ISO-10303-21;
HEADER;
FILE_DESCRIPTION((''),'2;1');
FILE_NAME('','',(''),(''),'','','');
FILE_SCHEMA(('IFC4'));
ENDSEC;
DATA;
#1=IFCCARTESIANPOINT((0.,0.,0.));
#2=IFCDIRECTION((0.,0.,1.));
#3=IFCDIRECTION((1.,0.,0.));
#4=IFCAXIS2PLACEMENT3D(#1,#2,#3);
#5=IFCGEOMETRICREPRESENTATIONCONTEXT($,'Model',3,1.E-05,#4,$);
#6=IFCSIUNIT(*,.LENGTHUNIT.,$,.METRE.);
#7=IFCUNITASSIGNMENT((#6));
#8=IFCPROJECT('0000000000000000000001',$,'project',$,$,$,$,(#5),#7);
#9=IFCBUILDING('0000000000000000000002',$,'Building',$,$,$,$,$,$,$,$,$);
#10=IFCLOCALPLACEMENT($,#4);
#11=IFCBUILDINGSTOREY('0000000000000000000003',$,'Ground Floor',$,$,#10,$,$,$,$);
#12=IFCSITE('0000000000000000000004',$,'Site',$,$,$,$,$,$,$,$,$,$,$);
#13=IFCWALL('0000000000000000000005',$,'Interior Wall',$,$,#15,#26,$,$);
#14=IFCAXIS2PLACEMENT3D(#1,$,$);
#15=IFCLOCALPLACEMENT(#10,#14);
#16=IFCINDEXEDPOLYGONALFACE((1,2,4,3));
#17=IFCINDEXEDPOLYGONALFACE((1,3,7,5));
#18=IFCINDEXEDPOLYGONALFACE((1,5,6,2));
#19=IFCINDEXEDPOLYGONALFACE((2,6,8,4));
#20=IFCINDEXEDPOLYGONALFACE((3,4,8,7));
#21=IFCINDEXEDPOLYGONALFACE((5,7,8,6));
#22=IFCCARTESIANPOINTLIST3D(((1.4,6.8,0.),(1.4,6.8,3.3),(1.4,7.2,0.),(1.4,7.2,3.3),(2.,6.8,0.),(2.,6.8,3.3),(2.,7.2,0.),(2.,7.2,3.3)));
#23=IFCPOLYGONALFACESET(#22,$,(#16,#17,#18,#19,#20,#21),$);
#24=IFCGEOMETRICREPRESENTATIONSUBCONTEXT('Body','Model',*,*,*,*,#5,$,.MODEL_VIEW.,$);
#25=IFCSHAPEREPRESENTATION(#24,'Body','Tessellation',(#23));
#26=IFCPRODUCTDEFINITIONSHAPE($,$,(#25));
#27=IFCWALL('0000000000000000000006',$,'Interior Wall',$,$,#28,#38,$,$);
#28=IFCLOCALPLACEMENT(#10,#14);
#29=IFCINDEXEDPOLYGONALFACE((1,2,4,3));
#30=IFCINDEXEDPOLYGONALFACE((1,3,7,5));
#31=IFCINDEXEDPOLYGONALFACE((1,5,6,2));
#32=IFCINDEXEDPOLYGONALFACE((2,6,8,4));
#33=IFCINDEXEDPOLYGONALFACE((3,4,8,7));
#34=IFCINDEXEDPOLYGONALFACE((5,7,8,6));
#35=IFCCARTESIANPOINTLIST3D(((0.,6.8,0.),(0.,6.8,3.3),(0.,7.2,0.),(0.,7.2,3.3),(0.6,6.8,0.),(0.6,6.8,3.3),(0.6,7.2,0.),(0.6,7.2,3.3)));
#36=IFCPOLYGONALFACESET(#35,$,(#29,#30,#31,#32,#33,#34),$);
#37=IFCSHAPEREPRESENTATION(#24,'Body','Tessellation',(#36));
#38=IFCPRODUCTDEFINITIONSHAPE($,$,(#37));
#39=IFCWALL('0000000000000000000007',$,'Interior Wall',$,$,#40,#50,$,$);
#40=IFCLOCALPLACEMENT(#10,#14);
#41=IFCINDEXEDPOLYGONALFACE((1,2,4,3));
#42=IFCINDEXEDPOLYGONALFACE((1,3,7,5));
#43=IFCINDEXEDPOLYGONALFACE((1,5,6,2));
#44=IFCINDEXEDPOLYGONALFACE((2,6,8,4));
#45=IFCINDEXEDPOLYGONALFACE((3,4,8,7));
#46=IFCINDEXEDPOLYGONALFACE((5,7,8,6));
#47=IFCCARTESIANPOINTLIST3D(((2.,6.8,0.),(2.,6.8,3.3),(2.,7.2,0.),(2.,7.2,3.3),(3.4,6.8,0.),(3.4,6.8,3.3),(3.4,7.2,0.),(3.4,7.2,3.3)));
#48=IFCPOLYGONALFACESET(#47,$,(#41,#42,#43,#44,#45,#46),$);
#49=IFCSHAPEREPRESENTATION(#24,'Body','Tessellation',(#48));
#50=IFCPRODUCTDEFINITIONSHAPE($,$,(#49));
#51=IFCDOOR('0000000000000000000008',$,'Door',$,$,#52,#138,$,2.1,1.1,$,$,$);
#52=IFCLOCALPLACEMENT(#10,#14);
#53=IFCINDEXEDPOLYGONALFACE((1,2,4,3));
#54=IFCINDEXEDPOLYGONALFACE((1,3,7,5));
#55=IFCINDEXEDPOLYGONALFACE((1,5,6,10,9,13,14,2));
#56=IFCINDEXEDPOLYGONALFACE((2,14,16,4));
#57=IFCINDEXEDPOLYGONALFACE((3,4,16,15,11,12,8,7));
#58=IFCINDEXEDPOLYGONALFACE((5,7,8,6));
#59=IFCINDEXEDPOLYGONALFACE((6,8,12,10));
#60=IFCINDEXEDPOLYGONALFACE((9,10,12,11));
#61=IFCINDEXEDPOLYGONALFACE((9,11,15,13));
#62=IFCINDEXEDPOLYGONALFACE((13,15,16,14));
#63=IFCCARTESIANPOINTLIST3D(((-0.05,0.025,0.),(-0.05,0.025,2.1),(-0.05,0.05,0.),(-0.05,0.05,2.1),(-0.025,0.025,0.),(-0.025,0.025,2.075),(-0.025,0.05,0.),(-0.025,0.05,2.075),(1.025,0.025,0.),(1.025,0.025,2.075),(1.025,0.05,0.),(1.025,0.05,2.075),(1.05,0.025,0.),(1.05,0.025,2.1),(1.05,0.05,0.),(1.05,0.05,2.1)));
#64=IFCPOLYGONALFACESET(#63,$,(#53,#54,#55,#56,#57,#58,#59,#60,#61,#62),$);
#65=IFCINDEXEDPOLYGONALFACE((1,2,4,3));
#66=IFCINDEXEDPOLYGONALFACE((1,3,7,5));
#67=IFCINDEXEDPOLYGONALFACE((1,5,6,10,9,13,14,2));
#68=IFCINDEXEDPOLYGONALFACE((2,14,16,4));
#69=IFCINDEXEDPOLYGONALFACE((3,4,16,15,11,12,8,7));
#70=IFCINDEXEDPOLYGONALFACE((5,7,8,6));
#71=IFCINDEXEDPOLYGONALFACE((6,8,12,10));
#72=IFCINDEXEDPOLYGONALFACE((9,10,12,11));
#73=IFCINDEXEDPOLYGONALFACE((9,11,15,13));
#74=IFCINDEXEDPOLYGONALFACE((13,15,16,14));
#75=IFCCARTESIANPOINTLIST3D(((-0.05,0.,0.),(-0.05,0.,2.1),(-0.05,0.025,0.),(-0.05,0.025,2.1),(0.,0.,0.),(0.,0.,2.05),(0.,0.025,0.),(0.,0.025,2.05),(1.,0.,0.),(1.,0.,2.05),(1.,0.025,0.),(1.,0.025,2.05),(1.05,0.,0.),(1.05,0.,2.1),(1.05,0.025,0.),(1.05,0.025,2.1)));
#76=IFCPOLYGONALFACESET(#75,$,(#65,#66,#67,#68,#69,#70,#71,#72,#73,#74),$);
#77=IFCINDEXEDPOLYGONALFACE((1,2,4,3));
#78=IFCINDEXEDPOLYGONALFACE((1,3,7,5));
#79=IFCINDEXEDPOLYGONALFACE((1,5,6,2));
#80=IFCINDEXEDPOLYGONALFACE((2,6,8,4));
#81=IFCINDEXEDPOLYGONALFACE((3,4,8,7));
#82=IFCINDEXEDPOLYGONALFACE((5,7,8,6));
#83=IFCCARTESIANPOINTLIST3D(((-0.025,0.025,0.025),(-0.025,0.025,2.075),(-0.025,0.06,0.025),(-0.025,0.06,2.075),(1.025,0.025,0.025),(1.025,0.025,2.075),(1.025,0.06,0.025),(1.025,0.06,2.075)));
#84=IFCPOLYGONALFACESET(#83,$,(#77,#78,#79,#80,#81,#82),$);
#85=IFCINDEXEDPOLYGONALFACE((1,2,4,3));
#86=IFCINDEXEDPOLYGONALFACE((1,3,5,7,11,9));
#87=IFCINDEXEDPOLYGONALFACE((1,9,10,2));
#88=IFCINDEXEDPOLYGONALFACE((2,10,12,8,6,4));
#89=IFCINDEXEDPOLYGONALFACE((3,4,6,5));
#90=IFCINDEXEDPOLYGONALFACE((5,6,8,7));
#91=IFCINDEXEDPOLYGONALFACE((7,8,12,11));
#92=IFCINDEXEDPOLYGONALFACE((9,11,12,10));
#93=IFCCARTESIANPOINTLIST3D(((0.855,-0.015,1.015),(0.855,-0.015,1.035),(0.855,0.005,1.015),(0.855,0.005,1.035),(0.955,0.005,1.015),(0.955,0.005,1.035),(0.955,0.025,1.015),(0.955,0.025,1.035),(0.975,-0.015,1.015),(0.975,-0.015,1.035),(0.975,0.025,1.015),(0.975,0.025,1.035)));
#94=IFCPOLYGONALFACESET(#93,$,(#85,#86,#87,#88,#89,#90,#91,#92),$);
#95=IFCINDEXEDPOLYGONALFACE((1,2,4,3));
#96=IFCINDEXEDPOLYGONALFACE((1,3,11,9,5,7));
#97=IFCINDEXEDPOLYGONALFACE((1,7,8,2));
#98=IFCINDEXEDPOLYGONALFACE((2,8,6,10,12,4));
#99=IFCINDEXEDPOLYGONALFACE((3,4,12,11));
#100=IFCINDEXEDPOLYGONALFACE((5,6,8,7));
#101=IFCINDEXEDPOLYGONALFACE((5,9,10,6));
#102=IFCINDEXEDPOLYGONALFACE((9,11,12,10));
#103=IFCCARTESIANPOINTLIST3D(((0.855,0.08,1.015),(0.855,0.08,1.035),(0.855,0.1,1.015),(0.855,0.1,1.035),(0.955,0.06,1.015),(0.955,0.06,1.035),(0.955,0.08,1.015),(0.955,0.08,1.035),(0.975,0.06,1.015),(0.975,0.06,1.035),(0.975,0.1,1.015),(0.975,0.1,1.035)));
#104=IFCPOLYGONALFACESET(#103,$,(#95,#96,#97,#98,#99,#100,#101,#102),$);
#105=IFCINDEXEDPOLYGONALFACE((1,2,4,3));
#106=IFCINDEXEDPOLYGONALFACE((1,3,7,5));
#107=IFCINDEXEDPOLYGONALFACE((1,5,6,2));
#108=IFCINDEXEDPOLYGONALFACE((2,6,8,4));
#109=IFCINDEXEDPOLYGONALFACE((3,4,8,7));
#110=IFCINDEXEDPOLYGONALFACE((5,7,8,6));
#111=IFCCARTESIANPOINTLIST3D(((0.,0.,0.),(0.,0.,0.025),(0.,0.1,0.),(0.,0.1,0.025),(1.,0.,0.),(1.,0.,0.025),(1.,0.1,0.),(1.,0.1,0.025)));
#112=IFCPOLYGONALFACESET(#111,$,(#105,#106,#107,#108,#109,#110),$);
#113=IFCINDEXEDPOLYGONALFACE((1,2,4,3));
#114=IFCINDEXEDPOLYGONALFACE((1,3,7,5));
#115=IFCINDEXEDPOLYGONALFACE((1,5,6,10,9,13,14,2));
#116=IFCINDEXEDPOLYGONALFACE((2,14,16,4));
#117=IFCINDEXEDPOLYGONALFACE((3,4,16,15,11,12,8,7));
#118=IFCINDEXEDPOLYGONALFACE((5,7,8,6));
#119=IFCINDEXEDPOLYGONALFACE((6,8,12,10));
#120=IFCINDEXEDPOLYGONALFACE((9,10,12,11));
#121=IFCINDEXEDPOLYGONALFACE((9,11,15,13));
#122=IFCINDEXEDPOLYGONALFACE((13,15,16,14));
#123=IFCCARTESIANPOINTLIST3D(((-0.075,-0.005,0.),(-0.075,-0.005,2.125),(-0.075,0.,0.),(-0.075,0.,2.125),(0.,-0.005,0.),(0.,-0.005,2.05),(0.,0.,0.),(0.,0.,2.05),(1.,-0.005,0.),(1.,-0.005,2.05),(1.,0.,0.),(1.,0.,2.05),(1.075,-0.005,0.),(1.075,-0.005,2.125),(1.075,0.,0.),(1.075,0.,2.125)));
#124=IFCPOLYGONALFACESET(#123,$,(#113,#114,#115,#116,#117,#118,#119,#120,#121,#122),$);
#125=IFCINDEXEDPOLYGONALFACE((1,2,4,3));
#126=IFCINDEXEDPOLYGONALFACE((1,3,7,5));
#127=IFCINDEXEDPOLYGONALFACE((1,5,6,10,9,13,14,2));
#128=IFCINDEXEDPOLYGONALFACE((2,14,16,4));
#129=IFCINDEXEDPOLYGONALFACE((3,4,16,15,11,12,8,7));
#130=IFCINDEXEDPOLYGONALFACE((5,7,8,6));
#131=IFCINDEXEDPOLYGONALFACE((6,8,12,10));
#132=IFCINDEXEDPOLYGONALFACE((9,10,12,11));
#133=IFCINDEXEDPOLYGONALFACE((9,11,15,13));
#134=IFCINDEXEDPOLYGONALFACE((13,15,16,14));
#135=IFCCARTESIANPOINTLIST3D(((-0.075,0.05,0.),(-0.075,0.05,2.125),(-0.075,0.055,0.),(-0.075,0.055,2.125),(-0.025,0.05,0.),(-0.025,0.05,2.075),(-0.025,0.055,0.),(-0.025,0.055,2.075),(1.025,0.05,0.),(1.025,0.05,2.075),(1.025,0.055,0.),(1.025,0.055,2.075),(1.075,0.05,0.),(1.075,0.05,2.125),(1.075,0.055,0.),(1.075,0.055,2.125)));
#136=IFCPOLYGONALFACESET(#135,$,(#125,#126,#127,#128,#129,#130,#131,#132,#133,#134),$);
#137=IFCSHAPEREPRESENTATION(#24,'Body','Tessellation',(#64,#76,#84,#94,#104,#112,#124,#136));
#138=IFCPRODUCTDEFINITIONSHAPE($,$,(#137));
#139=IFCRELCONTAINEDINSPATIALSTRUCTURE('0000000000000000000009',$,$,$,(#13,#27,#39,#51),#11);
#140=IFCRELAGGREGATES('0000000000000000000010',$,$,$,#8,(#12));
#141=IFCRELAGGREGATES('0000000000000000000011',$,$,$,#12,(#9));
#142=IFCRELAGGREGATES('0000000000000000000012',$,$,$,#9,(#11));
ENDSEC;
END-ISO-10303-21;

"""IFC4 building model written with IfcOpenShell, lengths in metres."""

from ifc_helpers import new_model, si_unit, frame, origin_with_axes, place, context, subcontext, project, spatial, line, indexed_curve, outline, extrude, element, save


model = new_model("IFC4")

# Units and contexts
model_context = context("Model", 3, precision=1e-05, world=origin_with_axes())
body_context = subcontext(model_context, "Body", "Model", "MODEL_VIEW")
ifc_project = project(units=[si_unit("LENGTHUNIT", "METRE")], contexts=[model_context])

# Site, building, storey
site = spatial("IfcSite", under=ifc_project, Name="Site")
building = spatial("IfcBuilding", under=site, Name="Building")
storey_placement = place(None, origin_with_axes())
storey = spatial("IfcBuildingStorey", under=building, at=storey_placement, Name="Ground Floor")

# Walls
for number, where, z_axis, x_axis, name in (
    (1, (2.0, 7.0, 0.0), (0.0, 0.0, 1.0), (-1.0, 0.0, 0.0), "Interior Wall"),
    (2, (0.6, 7.0, 0.0), (0.0, 0.0, 1.0), (-1.0, 0.0, 0.0), "Interior Wall"),
):
    element("IfcWall", number, at=place(storey_placement, frame(where, z_axis=z_axis, x_axis=x_axis)), inside=storey, Name=name, context=body_context, shape_type="SweptSolid", body=[
        extrude(outline(indexed_curve([(0.0, 0.0), (0.0, 0.4), (0.6, 0.4), (0.6, 0.0), (0.0, 0.0)], self_intersect=False)), frame((0.0, -0.2, 0.0), z_axis=(0.0, 0.0, 1.0), x_axis=(1.0, 0.0, 0.0)), (0.0, 0.0, 1.0), 3.3),
    ])
wall_1_placement = place(storey_placement, frame((3.4, 7.0, 0.0), z_axis=(0.0, 0.0, 1.0), x_axis=(-1.0, 0.0, 0.0)))
element("IfcWall", 3, at=wall_1_placement, inside=storey, Name="Interior Wall", context=body_context, shape_type="SweptSolid", body=[
    extrude(outline(indexed_curve([(0.0, 0.0), (0.0, 0.4), (1.4, 0.4), (1.4, 0.0), (0.0, 0.0)], self_intersect=False)), frame((0.0, -0.2, 0.0), z_axis=(0.0, 0.0, 1.0), x_axis=(1.0, 0.0, 0.0)), (0.0, 0.0, 1.0), 3.3),
])

# Door
door_1_placement = place(storey_placement, frame((-0.05, 0.0, 0.0), z_axis=(0.0, 0.0, 1.0), x_axis=(1.0, 0.0, 0.0)))
element("IfcDoor", 4, at=door_1_placement, inside=storey, Name="Door", OverallHeight=2.1, OverallWidth=1.1, context=body_context, shape_type="SweptSolid", body=[
    extrude(outline(indexed_curve([(0.0, 0.0), (0.0, 2.1), (1.1, 2.1), (1.1, 0.0), (1.075, 0.0), (1.075, 2.075), (0.025, 2.075), (0.025, 0.0)], segments=[line(1, 2, 3, 4, 5, 6, 7, 8, 1)])), frame((0.0, 0.025, 0.0), z_axis=(0.0, -1.0, 0.0), x_axis=(1.0, 0.0, 0.0)), (0.0, 0.0, -1.0), 0.025),
    extrude(outline(indexed_curve([(0.0, 0.0), (0.0, 2.1), (1.1, 2.1), (1.1, 0.0), (1.05, 0.0), (1.05, 2.05), (0.05, 2.05), (0.05, 0.0)], segments=[line(1, 2, 3, 4, 5, 6, 7, 8, 1)])), frame((0.0, 0.0, 0.0), z_axis=(0.0, -1.0, 0.0), x_axis=(1.0, 0.0, 0.0)), (0.0, 0.0, -1.0), 0.025),
    extrude(outline(indexed_curve([(0.0, 0.0), (1.05, 0.0), (1.05, 0.035), (0.0, 0.035)], segments=[line(1, 2, 3, 4, 1)])), frame((0.025, 0.025, 0.025), z_axis=(0.0, 0.0, 1.0), x_axis=(1.0, 0.0, 0.0)), (0.0, 0.0, 1.0), 2.05),
    extrude(outline(indexed_curve([(0.0, 0.0), (0.0, -0.04), (-0.12, -0.04), (-0.12, -0.02), (-0.02, -0.02), (-0.02, 0.0)], segments=[line(1, 2, 3, 4, 5, 6, 1)])), frame((1.025, 0.025, 1.015), z_axis=(0.0, 0.0, 1.0), x_axis=(1.0, 0.0, 0.0)), (0.0, 0.0, 1.0), 0.02),
    extrude(outline(indexed_curve([(0.0, 0.0), (0.0, 0.04), (-0.12, 0.04), (-0.12, 0.02), (-0.02, 0.02), (-0.02, 0.0)], segments=[line(1, 2, 3, 4, 5, 6, 1)])), frame((1.025, 0.06, 1.015), z_axis=(0.0, 0.0, 1.0), x_axis=(1.0, 0.0, 0.0)), (0.0, 0.0, 1.0), 0.02),
    extrude(outline(indexed_curve([(0.0, 0.0), (1.0, 0.0), (1.0, 0.1), (0.0, 0.1)], segments=[line(1, 2, 3, 4, 1)])), frame((0.05, 0.0, 0.0), z_axis=(0.0, 0.0, 1.0), x_axis=(1.0, 0.0, 0.0)), (0.0, 0.0, 1.0), 0.025),
    extrude(outline(indexed_curve([(0.0, 0.0), (0.0, 2.125), (1.15, 2.125), (1.15, 0.0), (1.075, 0.0), (1.075, 2.05), (0.075, 2.05), (0.075, 0.0)], segments=[line(1, 2, 3, 4, 5, 6, 7, 8, 1)])), frame((-0.025, -0.005, 0.0), z_axis=(0.0, -1.0, 0.0), x_axis=(1.0, 0.0, 0.0)), (0.0, 0.0, -1.0), 0.005),
    extrude(outline(indexed_curve([(0.0, 0.0), (0.0, 2.125), (1.15, 2.125), (1.15, 0.0), (1.1, 0.0), (1.1, 2.075), (0.05, 2.075), (0.05, 0.0)], segments=[line(1, 2, 3, 4, 5, 6, 7, 8, 1)])), frame((-0.025, 0.05, 0.0), z_axis=(0.0, -1.0, 0.0), x_axis=(1.0, 0.0, 0.0)), (0.0, 0.0, -1.0), 0.005),
])

save(model, "model.ifc")
